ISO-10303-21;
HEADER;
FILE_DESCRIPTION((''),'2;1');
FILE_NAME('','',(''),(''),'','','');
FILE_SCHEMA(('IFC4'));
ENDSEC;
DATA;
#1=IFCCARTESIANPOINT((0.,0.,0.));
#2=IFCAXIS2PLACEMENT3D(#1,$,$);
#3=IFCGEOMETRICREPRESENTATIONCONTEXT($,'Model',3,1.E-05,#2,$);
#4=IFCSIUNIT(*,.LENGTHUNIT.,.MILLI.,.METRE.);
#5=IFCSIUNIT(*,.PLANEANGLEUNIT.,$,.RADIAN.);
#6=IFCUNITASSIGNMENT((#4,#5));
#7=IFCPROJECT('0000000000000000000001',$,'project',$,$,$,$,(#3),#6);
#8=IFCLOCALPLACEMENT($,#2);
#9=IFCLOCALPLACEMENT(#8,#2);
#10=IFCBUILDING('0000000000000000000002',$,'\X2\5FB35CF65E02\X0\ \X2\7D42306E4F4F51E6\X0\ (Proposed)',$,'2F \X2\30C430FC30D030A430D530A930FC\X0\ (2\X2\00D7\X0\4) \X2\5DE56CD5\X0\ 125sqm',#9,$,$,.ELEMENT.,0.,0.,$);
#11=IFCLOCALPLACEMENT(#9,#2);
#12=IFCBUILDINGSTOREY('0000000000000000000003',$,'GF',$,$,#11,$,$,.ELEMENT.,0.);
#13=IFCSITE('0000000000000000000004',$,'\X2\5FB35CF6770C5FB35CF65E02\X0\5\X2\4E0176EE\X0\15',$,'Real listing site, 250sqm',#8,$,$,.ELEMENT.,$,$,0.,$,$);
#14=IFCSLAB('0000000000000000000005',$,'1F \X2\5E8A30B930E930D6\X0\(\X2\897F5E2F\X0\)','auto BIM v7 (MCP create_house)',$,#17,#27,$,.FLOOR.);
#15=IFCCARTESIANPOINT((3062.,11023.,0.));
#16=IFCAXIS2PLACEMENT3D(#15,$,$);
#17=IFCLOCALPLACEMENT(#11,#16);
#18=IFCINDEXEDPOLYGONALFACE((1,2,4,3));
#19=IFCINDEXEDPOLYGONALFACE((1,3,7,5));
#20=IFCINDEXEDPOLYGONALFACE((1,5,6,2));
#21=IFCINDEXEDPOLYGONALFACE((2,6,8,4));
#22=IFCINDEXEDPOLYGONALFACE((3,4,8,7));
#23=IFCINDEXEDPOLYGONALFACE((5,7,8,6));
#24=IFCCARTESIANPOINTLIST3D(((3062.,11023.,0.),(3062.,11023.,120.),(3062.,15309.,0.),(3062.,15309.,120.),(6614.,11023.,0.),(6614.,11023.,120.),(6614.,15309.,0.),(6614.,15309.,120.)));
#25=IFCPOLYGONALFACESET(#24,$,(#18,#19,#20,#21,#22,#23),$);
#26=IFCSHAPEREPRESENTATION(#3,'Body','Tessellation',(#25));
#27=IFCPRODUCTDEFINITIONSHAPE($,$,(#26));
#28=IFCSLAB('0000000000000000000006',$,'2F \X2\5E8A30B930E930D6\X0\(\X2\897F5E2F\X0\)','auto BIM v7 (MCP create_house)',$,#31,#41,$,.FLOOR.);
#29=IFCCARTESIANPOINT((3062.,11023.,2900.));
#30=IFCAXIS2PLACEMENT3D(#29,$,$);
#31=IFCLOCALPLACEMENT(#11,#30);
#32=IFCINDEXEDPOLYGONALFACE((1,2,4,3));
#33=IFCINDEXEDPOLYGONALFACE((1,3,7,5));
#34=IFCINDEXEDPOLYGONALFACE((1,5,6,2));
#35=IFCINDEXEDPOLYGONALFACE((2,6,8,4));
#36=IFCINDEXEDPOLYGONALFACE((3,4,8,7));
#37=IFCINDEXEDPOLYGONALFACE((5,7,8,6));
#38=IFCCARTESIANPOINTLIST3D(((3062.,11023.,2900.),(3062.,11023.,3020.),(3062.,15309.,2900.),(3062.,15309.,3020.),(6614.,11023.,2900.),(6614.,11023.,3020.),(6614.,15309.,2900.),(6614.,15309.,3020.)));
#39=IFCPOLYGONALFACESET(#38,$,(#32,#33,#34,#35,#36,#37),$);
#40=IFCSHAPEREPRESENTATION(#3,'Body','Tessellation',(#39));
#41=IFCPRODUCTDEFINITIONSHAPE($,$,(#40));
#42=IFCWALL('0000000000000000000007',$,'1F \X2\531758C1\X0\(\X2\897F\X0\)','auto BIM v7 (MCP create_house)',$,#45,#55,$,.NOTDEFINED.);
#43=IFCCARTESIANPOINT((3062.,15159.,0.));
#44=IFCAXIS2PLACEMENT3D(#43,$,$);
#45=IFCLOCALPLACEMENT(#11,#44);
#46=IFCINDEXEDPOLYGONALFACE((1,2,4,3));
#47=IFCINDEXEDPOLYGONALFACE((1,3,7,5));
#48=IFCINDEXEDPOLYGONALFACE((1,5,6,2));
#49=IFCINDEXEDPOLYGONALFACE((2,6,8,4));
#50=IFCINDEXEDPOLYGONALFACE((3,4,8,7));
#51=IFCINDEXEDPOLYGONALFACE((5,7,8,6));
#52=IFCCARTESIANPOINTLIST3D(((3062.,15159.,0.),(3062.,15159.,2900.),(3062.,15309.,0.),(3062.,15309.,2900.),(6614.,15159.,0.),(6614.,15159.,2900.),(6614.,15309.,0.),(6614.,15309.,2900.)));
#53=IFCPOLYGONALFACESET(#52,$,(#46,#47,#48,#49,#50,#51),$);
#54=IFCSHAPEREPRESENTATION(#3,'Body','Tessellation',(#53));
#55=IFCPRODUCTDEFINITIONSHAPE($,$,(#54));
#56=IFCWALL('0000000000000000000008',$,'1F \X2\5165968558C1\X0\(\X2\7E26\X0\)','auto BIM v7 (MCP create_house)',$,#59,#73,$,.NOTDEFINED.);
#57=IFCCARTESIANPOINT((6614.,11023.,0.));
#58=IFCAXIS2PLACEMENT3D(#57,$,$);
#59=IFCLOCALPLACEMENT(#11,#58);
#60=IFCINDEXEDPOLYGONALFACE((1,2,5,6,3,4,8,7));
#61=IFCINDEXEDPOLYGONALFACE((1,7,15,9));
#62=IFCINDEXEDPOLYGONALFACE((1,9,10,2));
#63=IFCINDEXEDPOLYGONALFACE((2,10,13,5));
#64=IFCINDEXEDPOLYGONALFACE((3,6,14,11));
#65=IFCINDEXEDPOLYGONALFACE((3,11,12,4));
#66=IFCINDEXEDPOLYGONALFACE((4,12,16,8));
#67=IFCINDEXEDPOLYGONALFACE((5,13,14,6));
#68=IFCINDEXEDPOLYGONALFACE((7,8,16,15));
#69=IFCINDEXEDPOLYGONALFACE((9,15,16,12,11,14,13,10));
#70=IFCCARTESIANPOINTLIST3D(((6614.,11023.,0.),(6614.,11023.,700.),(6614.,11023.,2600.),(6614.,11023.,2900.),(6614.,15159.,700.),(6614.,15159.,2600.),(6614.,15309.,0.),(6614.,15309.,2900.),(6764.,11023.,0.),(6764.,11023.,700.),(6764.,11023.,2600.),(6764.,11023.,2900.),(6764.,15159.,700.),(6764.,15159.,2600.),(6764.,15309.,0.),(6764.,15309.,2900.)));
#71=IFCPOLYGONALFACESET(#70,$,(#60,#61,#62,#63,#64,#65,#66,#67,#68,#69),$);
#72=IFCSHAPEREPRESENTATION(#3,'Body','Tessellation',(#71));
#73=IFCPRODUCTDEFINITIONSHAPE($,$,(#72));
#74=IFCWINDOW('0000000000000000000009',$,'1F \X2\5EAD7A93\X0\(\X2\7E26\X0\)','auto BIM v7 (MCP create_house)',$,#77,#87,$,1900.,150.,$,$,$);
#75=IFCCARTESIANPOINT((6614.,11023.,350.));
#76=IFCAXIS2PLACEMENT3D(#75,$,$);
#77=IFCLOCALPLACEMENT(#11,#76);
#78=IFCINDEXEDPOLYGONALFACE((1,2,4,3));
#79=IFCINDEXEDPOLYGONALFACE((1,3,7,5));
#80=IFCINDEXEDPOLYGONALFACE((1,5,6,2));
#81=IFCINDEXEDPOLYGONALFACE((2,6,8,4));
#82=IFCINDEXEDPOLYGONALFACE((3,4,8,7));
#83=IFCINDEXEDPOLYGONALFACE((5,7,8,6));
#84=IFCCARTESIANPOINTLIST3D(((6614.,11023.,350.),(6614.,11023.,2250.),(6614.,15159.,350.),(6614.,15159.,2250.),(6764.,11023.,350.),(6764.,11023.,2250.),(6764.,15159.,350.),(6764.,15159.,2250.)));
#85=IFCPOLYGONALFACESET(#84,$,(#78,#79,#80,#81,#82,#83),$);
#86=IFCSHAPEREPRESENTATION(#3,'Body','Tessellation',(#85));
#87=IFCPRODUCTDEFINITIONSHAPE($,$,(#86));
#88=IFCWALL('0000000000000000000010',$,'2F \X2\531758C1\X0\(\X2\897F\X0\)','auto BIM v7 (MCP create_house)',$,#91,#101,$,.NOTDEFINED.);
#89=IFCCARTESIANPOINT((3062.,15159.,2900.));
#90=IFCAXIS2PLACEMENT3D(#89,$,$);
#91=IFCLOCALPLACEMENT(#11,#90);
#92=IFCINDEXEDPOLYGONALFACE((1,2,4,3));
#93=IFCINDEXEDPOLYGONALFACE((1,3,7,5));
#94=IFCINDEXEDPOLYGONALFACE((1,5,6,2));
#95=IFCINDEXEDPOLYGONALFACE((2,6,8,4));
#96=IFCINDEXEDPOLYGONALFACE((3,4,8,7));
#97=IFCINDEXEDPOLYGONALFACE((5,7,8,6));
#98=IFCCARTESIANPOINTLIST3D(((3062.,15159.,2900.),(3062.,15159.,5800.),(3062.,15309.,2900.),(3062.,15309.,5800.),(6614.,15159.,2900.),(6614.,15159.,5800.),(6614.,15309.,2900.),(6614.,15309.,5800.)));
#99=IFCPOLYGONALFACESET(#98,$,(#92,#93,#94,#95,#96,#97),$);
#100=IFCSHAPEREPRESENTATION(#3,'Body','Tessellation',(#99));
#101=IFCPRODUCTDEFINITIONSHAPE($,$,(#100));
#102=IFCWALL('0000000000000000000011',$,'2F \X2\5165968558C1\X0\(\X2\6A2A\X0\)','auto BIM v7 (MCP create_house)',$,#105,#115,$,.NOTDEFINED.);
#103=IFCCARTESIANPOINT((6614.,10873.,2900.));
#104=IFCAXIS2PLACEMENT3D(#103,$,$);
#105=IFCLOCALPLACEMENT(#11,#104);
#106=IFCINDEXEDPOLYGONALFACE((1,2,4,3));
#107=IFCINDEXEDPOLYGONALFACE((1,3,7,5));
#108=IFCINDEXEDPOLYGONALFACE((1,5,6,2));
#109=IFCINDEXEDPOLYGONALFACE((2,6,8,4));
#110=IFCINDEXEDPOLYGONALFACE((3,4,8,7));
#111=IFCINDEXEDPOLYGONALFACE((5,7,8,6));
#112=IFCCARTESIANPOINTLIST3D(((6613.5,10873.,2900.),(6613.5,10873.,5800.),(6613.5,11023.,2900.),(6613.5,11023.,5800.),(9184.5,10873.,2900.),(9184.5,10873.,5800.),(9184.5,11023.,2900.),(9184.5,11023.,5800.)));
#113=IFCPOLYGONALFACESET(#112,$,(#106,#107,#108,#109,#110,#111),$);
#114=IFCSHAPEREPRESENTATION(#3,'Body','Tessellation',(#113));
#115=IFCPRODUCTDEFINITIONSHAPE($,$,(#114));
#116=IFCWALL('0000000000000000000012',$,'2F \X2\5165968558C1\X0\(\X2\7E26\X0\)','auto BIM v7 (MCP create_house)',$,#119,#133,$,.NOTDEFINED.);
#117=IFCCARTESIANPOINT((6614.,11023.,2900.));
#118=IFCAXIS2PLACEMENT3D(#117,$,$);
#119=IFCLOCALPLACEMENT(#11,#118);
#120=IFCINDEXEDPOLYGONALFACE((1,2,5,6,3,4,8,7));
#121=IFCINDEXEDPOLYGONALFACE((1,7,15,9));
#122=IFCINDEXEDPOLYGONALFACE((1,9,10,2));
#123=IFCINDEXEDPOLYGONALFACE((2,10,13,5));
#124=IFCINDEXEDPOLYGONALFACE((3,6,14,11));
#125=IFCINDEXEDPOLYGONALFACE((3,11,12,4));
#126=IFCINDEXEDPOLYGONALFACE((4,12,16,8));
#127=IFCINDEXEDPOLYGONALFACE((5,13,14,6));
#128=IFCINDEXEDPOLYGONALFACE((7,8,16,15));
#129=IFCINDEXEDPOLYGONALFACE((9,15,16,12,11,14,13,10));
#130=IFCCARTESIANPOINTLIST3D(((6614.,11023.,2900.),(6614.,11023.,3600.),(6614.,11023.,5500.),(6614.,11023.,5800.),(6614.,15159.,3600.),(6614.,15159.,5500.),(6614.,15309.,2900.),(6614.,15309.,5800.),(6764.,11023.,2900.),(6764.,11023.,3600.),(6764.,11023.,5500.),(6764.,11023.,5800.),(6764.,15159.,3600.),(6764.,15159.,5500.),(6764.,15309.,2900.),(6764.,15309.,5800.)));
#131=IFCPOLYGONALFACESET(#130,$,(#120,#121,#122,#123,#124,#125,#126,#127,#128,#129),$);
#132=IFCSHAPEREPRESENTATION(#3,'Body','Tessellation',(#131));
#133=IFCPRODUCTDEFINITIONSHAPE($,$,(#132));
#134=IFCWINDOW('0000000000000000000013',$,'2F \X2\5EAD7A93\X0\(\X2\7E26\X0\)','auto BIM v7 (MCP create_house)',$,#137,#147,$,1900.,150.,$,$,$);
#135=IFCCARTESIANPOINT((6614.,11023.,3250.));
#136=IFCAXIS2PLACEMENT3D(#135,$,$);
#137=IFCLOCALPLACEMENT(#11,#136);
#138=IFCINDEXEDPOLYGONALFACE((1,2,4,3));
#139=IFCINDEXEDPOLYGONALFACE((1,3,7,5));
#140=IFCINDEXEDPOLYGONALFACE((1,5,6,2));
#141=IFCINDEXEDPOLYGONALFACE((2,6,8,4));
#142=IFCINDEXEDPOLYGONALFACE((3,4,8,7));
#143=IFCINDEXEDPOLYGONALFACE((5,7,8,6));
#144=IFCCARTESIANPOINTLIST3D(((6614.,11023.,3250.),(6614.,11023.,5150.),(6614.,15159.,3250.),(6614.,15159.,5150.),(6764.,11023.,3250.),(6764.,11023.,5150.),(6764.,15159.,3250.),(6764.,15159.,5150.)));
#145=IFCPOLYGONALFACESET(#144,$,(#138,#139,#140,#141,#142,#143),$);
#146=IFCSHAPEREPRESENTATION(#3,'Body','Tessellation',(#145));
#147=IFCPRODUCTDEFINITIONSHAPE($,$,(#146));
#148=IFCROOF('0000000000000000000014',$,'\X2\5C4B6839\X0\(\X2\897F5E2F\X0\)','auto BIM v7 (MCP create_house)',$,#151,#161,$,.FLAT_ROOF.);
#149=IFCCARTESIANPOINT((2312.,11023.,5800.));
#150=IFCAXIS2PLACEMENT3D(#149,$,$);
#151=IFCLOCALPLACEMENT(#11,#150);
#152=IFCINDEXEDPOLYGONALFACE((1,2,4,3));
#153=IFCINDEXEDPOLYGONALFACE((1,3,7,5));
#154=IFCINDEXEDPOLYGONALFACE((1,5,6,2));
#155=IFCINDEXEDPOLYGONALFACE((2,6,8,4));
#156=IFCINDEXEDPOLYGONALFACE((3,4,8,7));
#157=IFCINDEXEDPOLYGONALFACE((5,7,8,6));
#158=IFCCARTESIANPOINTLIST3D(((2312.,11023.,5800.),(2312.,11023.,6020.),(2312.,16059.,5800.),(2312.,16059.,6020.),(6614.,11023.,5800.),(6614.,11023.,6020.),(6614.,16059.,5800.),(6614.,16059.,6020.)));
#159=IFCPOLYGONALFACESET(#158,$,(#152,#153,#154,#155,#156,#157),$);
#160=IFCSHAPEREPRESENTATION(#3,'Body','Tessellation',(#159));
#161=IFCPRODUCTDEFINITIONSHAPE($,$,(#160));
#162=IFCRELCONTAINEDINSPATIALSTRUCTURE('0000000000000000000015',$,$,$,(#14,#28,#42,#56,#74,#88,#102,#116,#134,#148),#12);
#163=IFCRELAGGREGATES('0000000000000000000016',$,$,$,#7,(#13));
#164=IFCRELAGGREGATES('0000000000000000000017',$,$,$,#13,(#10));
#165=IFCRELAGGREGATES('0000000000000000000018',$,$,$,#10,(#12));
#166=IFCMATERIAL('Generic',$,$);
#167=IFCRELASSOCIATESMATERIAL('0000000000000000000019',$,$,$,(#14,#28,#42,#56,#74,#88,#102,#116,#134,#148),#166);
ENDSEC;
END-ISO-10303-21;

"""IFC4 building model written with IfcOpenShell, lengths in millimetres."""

from ifc_helpers import new_model, si_unit, frame, frame_2d, origin, place, context, project, spatial, rectangle, extrude, material, element, fill, save


model = new_model("IFC4")

# Units and contexts
model_context = context("Model", 3, precision=1e-05, world=origin())
ifc_project = project(units=[si_unit("LENGTHUNIT", "METRE", prefix="MILLI"), si_unit("PLANEANGLEUNIT", "RADIAN")], contexts=[model_context])

# Site, building, storey
site_placement = place(None, origin())
site = spatial("IfcSite", under=ifc_project, at=site_placement, Name="徳島県徳島市5丁目15", ObjectType="Real listing site, 250sqm", CompositionType="ELEMENT", RefElevation=0.0)
building_placement = place(site_placement, origin())
building = spatial("IfcBuilding", under=site, at=building_placement, Name="徳島市 終の住処 (Proposed)", ObjectType="2F ツーバイフォー (2×4) 工法 125sqm", CompositionType="ELEMENT", ElevationOfRefHeight=0.0, ElevationOfTerrain=0.0)
storey_placement = place(building_placement, origin())
storey = spatial("IfcBuildingStorey", under=building, at=storey_placement, Name="GF", CompositionType="ELEMENT", Elevation=0.0)

# Slabs
ifc_material = material(Name="Generic")
slab_1_placement = place(storey_placement, frame((3062.0, 11023.0, 0.0)))
element("IfcSlab", 1, at=slab_1_placement, inside=storey, material=ifc_material, Name="1F 床スラブ(西帯)", Description="auto BIM v7 (MCP create_house)", PredefinedType="FLOOR", context=model_context, shape_type="SweptSolid", body=[
    extrude(rectangle(XDim=3552.0, YDim=4286.0, at=frame_2d((1776.0, 2143.0))), frame((3062.0, 11023.0, 0.0)), (0.0, 0.0, 1.0), 120.0),
])
slab_2_placement = place(storey_placement, frame((3062.0, 11023.0, 2900.0)))
element("IfcSlab", 2, at=slab_2_placement, inside=storey, material=ifc_material, Name="2F 床スラブ(西帯)", Description="auto BIM v7 (MCP create_house)", PredefinedType="FLOOR", context=model_context, shape_type="SweptSolid", body=[
    extrude(rectangle(XDim=3552.0, YDim=4286.0, at=frame_2d((1776.0, 2143.0))), frame((3062.0, 11023.0, 2900.0)), (0.0, 0.0, 1.0), 120.0),
])

# Wall
wall_1_placement = place(storey_placement, frame((3062.0, 15159.0, 0.0)))
element("IfcWall", 3, at=wall_1_placement, inside=storey, material=ifc_material, Name="1F 北壁(西)", Description="auto BIM v7 (MCP create_house)", PredefinedType="NOTDEFINED", context=model_context, shape_type="SweptSolid", body=[
    extrude(rectangle(XDim=3552.0, YDim=150.0, at=frame_2d((1776.0, 75.0))), frame((3062.0, 15159.0, 0.0)), (0.0, 0.0, 1.0), 2900.0),
])

# Wall, opening, window
wall_2_placement = place(storey_placement, frame((6614.0, 11023.0, 0.0)))
wall_2 = element("IfcWall", 4, at=wall_2_placement, inside=storey, material=ifc_material, Name="1F 入隅壁(縦)", Description="auto BIM v7 (MCP create_house)", PredefinedType="NOTDEFINED", context=model_context, shape_type="SweptSolid", body=[
    extrude(rectangle(XDim=150.0, YDim=4286.0, at=frame_2d((75.0, 2143.0))), frame((6614.0, 11023.0, 0.0)), (0.0, 0.0, 1.0), 2900.0),
])
opening_1_placement = place(storey_placement, frame((6614.0, 11023.0, 350.0)))
opening_1 = element("IfcOpeningElement", 5, at=opening_1_placement, cuts=wall_2, PredefinedType="NOTDEFINED", context=model_context, shape_type="SweptSolid", body=[
    extrude(rectangle(XDim=150.0, YDim=4136.0, at=frame_2d((75.0, 2068.0))), frame((6614.0, 11023.0, 350.0)), (0.0, 0.0, 1.0), 1900.0),
])
window_1_placement = place(storey_placement, frame((6614.0, 11023.0, 350.0)))
window_1 = element("IfcWindow", 6, at=window_1_placement, inside=storey, material=ifc_material, Name="1F 庭窓(縦)", Description="auto BIM v7 (MCP create_house)", OverallHeight=1900.0, OverallWidth=150.0, context=model_context, shape_type="SweptSolid", body=[
    extrude(rectangle(XDim=150.0, YDim=4136.0, at=frame_2d((75.0, 2068.0))), frame((6614.0, 11023.0, 350.0)), (0.0, 0.0, 1.0), 1900.0),
])
fill(opening_1, window_1)

# Walls
wall_3_placement = place(storey_placement, frame((3062.0, 15159.0, 2900.0)))
element("IfcWall", 7, at=wall_3_placement, inside=storey, material=ifc_material, Name="2F 北壁(西)", Description="auto BIM v7 (MCP create_house)", PredefinedType="NOTDEFINED", context=model_context, shape_type="SweptSolid", body=[
    extrude(rectangle(XDim=3552.0, YDim=150.0, at=frame_2d((1776.0, 75.0))), frame((3062.0, 15159.0, 2900.0)), (0.0, 0.0, 1.0), 2900.0),
])
wall_4_placement = place(storey_placement, frame((6614.0, 10873.0, 2900.0)))
element("IfcWall", 8, at=wall_4_placement, inside=storey, material=ifc_material, Name="2F 入隅壁(横)", Description="auto BIM v7 (MCP create_house)", PredefinedType="NOTDEFINED", context=model_context, shape_type="SweptSolid", body=[
    extrude(rectangle(XDim=2571.0, YDim=150.0, at=frame_2d((1285.0, 75.0))), frame((6614.0, 10873.0, 2900.0)), (0.0, 0.0, 1.0), 2900.0),
])

# Wall, opening, window
wall_5_placement = place(storey_placement, frame((6614.0, 11023.0, 2900.0)))
wall_5 = element("IfcWall", 9, at=wall_5_placement, inside=storey, material=ifc_material, Name="2F 入隅壁(縦)", Description="auto BIM v7 (MCP create_house)", PredefinedType="NOTDEFINED", context=model_context, shape_type="SweptSolid", body=[
    extrude(rectangle(XDim=150.0, YDim=4286.0, at=frame_2d((75.0, 2143.0))), frame((6614.0, 11023.0, 2900.0)), (0.0, 0.0, 1.0), 2900.0),
])
opening_2_placement = place(storey_placement, frame((6614.0, 11023.0, 3250.0)))
opening_2 = element("IfcOpeningElement", 10, at=opening_2_placement, cuts=wall_5, PredefinedType="NOTDEFINED", context=model_context, shape_type="SweptSolid", body=[
    extrude(rectangle(XDim=150.0, YDim=4136.0, at=frame_2d((75.0, 2068.0))), frame((6614.0, 11023.0, 3250.0)), (0.0, 0.0, 1.0), 1900.0),
])
window_2_placement = place(storey_placement, frame((6614.0, 11023.0, 3250.0)))
window_2 = element("IfcWindow", 11, at=window_2_placement, inside=storey, material=ifc_material, Name="2F 庭窓(縦)", Description="auto BIM v7 (MCP create_house)", OverallHeight=1900.0, OverallWidth=150.0, context=model_context, shape_type="SweptSolid", body=[
    extrude(rectangle(XDim=150.0, YDim=4136.0, at=frame_2d((75.0, 2068.0))), frame((6614.0, 11023.0, 3250.0)), (0.0, 0.0, 1.0), 1900.0),
])
fill(opening_2, window_2)

# Roof
for number, where, name in (
    (12, (2312.0, 11023.0, 5800.0), "屋根(西帯)"),
):
    element("IfcRoof", number, at=place(storey_placement, frame(where)), inside=storey, material=ifc_material, Name=name, Description="auto BIM v7 (MCP create_house)", PredefinedType="FLAT_ROOF", context=model_context, shape_type="SweptSolid", body=[
        extrude(rectangle(XDim=4302.0, YDim=5036.0, at=frame_2d((2151.0, 2518.0))), frame((2312.0, 11023.0, 5800.0)), (0.0, 0.0, 1.0), 220.0),
    ])

save(model, "model.ifc")
